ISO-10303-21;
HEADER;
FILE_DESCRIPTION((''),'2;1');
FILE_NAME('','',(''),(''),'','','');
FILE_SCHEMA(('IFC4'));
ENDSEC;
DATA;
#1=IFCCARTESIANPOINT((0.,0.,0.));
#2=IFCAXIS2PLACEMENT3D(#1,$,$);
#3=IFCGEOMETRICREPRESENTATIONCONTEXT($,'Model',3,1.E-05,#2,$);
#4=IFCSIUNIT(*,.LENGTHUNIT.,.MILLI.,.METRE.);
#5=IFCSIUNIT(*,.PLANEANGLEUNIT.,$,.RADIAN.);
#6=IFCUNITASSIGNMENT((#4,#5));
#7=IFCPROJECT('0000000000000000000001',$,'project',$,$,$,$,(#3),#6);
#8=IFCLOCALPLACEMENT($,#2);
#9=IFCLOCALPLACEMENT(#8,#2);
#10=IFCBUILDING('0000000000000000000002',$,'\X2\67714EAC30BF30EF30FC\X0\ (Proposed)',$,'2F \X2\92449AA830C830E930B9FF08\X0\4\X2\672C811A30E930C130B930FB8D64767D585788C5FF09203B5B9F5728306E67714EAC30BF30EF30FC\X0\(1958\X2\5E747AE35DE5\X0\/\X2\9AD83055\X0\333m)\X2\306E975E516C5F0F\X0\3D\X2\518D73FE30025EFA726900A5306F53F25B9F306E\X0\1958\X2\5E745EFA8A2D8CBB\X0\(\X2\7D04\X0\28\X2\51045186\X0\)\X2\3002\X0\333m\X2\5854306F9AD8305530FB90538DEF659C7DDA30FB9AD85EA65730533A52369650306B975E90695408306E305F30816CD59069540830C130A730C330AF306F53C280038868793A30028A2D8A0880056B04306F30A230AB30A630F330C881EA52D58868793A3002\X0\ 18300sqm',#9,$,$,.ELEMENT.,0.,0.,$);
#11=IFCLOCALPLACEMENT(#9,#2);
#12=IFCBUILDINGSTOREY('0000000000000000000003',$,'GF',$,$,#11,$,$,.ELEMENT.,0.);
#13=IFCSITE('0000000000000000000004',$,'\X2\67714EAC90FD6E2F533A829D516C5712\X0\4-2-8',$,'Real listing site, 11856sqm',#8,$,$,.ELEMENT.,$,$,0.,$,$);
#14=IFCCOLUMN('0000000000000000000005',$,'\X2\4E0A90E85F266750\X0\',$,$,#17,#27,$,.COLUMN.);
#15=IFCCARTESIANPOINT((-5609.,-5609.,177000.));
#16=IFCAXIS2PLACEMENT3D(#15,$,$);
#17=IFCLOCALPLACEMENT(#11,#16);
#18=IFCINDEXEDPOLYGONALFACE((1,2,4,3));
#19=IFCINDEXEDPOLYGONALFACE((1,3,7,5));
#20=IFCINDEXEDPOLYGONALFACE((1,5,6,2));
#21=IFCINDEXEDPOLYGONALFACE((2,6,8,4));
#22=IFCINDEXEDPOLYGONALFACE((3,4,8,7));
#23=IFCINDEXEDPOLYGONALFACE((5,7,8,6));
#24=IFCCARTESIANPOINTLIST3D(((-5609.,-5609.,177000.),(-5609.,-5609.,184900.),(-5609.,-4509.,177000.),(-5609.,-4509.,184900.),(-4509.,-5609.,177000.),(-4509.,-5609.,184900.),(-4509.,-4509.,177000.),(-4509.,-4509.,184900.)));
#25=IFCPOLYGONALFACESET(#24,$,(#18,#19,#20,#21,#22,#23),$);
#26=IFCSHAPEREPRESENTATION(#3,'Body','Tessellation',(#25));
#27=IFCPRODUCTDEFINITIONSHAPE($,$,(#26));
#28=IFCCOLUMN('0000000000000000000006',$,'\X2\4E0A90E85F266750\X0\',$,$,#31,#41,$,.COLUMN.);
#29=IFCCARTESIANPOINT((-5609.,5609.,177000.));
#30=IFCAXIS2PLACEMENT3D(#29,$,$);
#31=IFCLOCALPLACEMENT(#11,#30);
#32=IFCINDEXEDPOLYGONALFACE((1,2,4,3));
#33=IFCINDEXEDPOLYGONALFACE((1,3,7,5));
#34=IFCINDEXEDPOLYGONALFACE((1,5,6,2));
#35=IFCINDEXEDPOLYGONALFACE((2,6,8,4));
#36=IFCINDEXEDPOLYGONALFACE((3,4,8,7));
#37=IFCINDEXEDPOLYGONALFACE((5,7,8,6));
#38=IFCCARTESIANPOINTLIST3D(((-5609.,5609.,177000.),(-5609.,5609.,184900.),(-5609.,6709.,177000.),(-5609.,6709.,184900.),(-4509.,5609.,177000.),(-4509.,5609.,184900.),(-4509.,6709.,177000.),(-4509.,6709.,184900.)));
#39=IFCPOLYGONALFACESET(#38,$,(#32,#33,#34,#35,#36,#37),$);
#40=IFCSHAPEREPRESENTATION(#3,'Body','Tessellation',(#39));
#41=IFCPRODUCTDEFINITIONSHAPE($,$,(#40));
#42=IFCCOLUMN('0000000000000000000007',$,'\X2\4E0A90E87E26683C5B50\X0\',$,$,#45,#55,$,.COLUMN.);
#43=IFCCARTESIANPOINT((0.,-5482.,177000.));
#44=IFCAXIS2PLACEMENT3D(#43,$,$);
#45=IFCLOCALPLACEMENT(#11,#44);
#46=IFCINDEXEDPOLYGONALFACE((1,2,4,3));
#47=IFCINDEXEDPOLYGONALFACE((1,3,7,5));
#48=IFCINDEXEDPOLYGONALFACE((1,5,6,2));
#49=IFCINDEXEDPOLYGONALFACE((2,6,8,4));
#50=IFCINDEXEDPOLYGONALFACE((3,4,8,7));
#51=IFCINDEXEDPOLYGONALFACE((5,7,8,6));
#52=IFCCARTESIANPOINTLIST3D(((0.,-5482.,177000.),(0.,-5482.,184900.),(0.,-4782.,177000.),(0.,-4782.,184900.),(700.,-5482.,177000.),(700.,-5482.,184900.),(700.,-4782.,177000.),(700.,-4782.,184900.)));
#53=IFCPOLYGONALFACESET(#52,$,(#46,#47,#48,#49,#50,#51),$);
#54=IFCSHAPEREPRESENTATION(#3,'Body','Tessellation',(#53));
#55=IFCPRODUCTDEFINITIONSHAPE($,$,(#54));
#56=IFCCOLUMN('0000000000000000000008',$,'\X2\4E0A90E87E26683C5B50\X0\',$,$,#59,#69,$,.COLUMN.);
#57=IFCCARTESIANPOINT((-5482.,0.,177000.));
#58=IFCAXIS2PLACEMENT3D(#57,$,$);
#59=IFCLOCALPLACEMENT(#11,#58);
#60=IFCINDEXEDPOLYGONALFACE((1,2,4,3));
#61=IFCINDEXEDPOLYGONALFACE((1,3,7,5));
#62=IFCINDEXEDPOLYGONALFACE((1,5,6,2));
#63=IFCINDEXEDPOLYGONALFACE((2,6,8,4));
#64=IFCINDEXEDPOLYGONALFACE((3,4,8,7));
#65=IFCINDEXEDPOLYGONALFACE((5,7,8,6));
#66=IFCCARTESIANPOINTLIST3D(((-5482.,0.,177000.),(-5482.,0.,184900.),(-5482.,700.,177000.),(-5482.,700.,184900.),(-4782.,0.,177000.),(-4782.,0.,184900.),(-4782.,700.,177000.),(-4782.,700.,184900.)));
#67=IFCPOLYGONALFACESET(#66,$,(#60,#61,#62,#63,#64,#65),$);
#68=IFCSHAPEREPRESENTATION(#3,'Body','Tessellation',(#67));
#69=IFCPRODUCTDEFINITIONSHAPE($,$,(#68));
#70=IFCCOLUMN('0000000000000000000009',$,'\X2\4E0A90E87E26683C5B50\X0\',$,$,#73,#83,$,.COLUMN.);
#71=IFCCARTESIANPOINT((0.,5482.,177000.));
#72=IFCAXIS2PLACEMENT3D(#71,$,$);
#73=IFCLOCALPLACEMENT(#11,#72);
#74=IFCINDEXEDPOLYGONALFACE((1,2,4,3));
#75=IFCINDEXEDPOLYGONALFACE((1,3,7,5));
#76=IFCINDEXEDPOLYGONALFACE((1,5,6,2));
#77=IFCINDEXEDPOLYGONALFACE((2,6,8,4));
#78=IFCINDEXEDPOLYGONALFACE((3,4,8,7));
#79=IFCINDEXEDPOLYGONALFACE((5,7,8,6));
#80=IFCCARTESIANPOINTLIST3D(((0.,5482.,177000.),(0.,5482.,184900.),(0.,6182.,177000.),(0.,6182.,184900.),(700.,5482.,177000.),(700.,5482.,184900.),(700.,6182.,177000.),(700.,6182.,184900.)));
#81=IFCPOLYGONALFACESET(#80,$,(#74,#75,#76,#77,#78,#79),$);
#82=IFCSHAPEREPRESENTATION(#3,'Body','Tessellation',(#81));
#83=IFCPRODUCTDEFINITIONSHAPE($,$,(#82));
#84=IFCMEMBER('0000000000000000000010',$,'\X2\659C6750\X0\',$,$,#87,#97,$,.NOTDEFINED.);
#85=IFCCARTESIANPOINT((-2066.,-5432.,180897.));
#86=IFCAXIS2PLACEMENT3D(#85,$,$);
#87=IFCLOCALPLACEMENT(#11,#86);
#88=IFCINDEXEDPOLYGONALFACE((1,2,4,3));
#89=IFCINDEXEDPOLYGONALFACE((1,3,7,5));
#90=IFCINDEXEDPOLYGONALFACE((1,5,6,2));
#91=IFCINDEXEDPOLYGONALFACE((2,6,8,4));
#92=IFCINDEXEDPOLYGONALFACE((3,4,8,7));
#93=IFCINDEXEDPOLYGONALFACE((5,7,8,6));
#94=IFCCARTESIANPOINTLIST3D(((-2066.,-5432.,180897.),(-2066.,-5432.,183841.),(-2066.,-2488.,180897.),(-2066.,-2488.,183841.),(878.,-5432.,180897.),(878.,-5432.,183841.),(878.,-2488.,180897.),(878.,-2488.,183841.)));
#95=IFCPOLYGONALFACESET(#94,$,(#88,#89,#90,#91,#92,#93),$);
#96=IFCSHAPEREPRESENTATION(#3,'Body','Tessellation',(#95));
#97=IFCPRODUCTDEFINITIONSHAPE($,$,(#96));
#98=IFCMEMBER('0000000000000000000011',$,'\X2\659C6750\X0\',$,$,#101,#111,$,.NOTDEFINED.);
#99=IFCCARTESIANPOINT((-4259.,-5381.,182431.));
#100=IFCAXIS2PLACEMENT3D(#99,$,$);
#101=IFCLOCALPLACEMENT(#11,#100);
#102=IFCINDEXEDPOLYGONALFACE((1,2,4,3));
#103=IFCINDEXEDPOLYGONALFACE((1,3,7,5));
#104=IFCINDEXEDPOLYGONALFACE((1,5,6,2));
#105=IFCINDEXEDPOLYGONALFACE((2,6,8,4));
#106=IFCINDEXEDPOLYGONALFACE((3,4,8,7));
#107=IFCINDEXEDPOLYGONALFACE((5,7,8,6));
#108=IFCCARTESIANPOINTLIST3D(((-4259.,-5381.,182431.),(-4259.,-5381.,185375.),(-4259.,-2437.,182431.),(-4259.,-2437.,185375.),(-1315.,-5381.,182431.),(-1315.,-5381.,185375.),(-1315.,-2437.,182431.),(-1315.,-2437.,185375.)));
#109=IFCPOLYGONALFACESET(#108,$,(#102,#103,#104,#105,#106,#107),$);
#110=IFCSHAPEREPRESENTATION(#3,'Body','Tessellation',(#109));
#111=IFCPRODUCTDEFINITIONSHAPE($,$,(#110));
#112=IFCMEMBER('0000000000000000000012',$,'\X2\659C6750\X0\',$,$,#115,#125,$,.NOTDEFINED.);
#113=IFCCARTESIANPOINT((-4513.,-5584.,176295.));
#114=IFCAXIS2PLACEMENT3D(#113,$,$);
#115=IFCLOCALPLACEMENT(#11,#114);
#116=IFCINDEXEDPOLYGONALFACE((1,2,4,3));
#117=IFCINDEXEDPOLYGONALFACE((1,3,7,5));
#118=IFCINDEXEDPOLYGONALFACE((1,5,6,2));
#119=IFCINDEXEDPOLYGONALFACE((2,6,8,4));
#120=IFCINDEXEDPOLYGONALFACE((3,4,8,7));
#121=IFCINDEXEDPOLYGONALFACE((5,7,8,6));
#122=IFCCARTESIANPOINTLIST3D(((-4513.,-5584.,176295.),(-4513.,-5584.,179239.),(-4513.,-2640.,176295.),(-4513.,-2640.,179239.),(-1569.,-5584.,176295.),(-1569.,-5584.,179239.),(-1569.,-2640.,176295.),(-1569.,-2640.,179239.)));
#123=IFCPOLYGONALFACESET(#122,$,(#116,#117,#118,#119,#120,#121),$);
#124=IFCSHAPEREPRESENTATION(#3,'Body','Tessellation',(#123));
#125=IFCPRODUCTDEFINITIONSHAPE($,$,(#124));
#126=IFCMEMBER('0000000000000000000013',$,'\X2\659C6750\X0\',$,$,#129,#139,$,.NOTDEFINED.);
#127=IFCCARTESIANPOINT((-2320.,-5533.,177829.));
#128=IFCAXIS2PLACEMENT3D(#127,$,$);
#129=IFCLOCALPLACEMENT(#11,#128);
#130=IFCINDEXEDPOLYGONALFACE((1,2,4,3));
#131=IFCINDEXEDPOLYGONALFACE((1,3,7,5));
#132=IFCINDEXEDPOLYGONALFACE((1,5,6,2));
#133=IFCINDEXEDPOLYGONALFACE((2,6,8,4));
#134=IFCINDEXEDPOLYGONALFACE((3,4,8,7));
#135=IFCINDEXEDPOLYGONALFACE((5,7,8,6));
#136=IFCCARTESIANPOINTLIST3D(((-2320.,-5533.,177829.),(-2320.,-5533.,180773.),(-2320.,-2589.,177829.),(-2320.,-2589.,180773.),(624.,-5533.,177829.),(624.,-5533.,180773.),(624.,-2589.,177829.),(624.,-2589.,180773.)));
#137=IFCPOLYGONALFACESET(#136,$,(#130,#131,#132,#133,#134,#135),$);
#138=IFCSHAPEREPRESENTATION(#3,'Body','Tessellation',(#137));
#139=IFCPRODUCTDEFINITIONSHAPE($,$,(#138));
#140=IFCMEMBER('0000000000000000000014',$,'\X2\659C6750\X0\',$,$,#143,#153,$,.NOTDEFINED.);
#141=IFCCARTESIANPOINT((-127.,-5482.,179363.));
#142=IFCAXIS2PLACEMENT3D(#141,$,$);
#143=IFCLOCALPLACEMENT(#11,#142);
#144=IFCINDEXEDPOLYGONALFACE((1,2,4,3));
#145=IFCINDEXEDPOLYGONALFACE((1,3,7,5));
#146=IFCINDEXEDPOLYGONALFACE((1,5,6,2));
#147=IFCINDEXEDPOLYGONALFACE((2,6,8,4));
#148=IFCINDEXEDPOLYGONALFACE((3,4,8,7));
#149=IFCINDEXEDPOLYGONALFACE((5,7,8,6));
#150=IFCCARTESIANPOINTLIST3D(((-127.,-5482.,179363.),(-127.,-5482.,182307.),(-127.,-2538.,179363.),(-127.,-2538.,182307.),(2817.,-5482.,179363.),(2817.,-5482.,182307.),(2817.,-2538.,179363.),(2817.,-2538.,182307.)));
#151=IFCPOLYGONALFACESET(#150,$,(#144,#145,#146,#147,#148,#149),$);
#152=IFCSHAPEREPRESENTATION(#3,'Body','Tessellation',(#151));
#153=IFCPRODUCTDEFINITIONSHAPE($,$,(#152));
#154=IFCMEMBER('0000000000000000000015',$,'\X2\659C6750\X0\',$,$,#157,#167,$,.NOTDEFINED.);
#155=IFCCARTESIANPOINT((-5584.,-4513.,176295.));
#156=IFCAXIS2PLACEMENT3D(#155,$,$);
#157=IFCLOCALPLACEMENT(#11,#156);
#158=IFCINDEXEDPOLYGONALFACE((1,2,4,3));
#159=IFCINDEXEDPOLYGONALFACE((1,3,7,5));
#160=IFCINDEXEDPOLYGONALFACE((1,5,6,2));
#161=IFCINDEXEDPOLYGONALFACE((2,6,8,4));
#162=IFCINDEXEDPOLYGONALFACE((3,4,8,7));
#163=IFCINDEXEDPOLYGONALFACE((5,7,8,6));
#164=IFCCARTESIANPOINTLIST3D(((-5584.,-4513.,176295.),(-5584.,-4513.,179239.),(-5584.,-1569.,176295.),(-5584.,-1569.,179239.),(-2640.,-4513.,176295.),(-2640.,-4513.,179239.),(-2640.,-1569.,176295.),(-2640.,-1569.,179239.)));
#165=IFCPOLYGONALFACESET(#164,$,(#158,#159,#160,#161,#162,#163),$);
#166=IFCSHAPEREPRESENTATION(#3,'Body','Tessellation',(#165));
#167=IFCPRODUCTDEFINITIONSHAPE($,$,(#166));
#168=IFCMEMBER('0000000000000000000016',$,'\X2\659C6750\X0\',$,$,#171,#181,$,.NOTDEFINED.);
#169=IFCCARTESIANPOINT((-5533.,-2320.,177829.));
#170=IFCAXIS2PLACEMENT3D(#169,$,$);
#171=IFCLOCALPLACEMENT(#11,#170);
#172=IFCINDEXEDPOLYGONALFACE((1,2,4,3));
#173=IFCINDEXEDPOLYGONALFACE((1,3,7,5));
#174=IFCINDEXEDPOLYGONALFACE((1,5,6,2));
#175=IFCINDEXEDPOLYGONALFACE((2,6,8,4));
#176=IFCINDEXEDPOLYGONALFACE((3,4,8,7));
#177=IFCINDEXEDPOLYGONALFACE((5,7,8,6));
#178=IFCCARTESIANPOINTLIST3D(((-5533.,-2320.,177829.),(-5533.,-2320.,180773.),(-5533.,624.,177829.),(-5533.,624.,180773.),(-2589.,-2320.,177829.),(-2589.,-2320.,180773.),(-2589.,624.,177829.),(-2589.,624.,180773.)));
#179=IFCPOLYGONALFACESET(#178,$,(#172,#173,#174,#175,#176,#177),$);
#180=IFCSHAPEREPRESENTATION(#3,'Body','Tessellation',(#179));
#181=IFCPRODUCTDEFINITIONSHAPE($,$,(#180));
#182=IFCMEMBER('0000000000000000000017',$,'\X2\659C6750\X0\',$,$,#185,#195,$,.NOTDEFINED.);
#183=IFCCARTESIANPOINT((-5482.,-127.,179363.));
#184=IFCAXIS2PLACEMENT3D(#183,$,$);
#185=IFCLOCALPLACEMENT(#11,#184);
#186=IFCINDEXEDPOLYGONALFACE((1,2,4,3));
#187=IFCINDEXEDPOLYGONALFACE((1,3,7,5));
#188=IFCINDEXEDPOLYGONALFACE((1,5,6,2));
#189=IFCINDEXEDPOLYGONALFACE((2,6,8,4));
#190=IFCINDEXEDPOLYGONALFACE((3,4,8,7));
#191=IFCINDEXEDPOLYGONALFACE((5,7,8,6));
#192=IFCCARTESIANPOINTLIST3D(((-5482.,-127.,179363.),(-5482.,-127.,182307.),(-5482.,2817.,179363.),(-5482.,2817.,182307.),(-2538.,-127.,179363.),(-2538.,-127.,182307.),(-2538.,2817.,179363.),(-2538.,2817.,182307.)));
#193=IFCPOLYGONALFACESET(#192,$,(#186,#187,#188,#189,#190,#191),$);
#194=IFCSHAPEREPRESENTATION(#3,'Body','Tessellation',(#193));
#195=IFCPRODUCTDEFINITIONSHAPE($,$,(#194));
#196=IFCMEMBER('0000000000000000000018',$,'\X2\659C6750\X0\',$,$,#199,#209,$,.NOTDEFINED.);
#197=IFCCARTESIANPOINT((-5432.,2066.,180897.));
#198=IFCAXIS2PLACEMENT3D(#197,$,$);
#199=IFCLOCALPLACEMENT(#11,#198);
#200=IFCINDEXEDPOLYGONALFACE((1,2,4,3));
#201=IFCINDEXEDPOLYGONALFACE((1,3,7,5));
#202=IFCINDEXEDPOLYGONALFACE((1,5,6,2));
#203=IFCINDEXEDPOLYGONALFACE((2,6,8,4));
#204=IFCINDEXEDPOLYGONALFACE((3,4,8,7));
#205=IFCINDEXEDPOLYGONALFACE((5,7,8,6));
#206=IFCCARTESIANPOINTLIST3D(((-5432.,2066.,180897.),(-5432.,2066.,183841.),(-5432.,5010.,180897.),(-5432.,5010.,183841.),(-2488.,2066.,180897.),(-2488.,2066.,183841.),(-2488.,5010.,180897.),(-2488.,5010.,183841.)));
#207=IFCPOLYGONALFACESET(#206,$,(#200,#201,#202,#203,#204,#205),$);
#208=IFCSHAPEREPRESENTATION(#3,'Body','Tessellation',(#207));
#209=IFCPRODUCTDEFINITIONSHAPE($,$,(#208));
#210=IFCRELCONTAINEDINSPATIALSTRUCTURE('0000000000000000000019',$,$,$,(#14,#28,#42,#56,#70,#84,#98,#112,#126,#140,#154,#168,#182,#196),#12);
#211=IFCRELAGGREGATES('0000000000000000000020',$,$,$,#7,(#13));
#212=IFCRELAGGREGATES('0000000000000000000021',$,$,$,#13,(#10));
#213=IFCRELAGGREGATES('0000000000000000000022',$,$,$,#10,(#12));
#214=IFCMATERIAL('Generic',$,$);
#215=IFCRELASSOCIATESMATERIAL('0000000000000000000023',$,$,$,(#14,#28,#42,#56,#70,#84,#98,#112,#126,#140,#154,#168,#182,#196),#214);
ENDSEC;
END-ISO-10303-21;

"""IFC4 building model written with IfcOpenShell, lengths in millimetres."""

from ifc_helpers import new_model, si_unit, frame, frame_2d, origin, place, context, project, spatial, rectangle, extrude, material, element, save


model = new_model("IFC4")

# Units and contexts
model_context = context("Model", 3, precision=1e-05, world=origin())
ifc_project = project(units=[si_unit("LENGTHUNIT", "METRE", prefix="MILLI"), si_unit("PLANEANGLEUNIT", "RADIAN")], contexts=[model_context])

# Site, building, storey
site_placement = place(None, origin())
site = spatial("IfcSite", under=ifc_project, at=site_placement, Name="東京都港区芝公園4-2-8", ObjectType="Real listing site, 11856sqm", CompositionType="ELEMENT", RefElevation=0.0)
building_placement = place(site_placement, origin())
building = spatial("IfcBuilding", under=site, at=building_placement, Name="東京タワー (Proposed)", ObjectType="2F 鉄骨トラス（4本脚ラチス・赤白塗装）※実在の東京タワー(1958年竣工/高さ333m)の非公式3D再現。建物¥は史実の1958年建設費(約28億円)。333m塔は高さ・道路斜線・高度地区制限に非適合のため法適合チェックは参考表示。設計者欄はアカウント自動表示。 18300sqm", CompositionType="ELEMENT", ElevationOfRefHeight=0.0, ElevationOfTerrain=0.0)
storey_placement = place(building_placement, origin())
storey = spatial("IfcBuildingStorey", under=building, at=storey_placement, Name="GF", CompositionType="ELEMENT", Elevation=0.0)

# Columns
ifc_material = material(Name="Generic")
column_1_placement = place(storey_placement, frame((-5609.0, -5609.0, 177000.0)))
element("IfcColumn", 1, at=column_1_placement, inside=storey, material=ifc_material, Name="上部弦材", PredefinedType="COLUMN", context=model_context, shape_type="SweptSolid", body=[
    extrude(rectangle(XDim=1100.0, YDim=1100.0, at=frame_2d((550.0, 550.0))), frame((-5609.0, -5609.0, 177000.0)), (0.0, 0.0, 1.0), 7900.0),
])
column_2_placement = place(storey_placement, frame((-5609.0, 5609.0, 177000.0)))
element("IfcColumn", 2, at=column_2_placement, inside=storey, material=ifc_material, Name="上部弦材", PredefinedType="COLUMN", context=model_context, shape_type="SweptSolid", body=[
    extrude(rectangle(XDim=1100.0, YDim=1100.0, at=frame_2d((550.0, 550.0))), frame((-5609.0, 5609.0, 177000.0)), (0.0, 0.0, 1.0), 7900.0),
])
column_3_placement = place(storey_placement, frame((0.0, -5482.0, 177000.0)))
element("IfcColumn", 3, at=column_3_placement, inside=storey, material=ifc_material, Name="上部縦格子", PredefinedType="COLUMN", context=model_context, shape_type="SweptSolid", body=[
    extrude(rectangle(XDim=700.0, YDim=700.0, at=frame_2d((350.0, 350.0))), frame((0.0, -5482.0, 177000.0)), (0.0, 0.0, 1.0), 7900.0),
])
column_4_placement = place(storey_placement, frame((-5482.0, 0.0, 177000.0)))
element("IfcColumn", 4, at=column_4_placement, inside=storey, material=ifc_material, Name="上部縦格子", PredefinedType="COLUMN", context=model_context, shape_type="SweptSolid", body=[
    extrude(rectangle(XDim=700.0, YDim=700.0, at=frame_2d((350.0, 350.0))), frame((-5482.0, 0.0, 177000.0)), (0.0, 0.0, 1.0), 7900.0),
])
column_5_placement = place(storey_placement, frame((0.0, 5482.0, 177000.0)))
element("IfcColumn", 5, at=column_5_placement, inside=storey, material=ifc_material, Name="上部縦格子", PredefinedType="COLUMN", context=model_context, shape_type="SweptSolid", body=[
    extrude(rectangle(XDim=700.0, YDim=700.0, at=frame_2d((350.0, 350.0))), frame((0.0, 5482.0, 177000.0)), (0.0, 0.0, 1.0), 7900.0),
])

# Members
member_1_placement = place(storey_placement, frame((-2066.0, -5432.0, 180897.0)))
element("IfcMember", 6, at=member_1_placement, inside=storey, material=ifc_material, Name="斜材", PredefinedType="NOTDEFINED", context=model_context, shape_type="SweptSolid", body=[
    extrude(rectangle(XDim=2944.0, YDim=2944.0, at=frame_2d((1472.0, 1472.0))), frame((-2066.0, -5432.0, 180897.0)), (0.0, 0.0, 1.0), 2944.0),
])
member_2_placement = place(storey_placement, frame((-4259.0, -5381.0, 182431.0)))
element("IfcMember", 7, at=member_2_placement, inside=storey, material=ifc_material, Name="斜材", PredefinedType="NOTDEFINED", context=model_context, shape_type="SweptSolid", body=[
    extrude(rectangle(XDim=2944.0, YDim=2944.0, at=frame_2d((1472.0, 1472.0))), frame((-4259.0, -5381.0, 182431.0)), (0.0, 0.0, 1.0), 2944.0),
])
member_3_placement = place(storey_placement, frame((-4513.0, -5584.0, 176295.0)))
element("IfcMember", 8, at=member_3_placement, inside=storey, material=ifc_material, Name="斜材", PredefinedType="NOTDEFINED", context=model_context, shape_type="SweptSolid", body=[
    extrude(rectangle(XDim=2944.0, YDim=2944.0, at=frame_2d((1472.0, 1472.0))), frame((-4513.0, -5584.0, 176295.0)), (0.0, 0.0, 1.0), 2944.0),
])
member_4_placement = place(storey_placement, frame((-2320.0, -5533.0, 177829.0)))
element("IfcMember", 9, at=member_4_placement, inside=storey, material=ifc_material, Name="斜材", PredefinedType="NOTDEFINED", context=model_context, shape_type="SweptSolid", body=[
    extrude(rectangle(XDim=2944.0, YDim=2944.0, at=frame_2d((1472.0, 1472.0))), frame((-2320.0, -5533.0, 177829.0)), (0.0, 0.0, 1.0), 2944.0),
])
member_5_placement = place(storey_placement, frame((-127.0, -5482.0, 179363.0)))
element("IfcMember", 10, at=member_5_placement, inside=storey, material=ifc_material, Name="斜材", PredefinedType="NOTDEFINED", context=model_context, shape_type="SweptSolid", body=[
    extrude(rectangle(XDim=2944.0, YDim=2944.0, at=frame_2d((1472.0, 1472.0))), frame((-127.0, -5482.0, 179363.0)), (0.0, 0.0, 1.0), 2944.0),
])
member_6_placement = place(storey_placement, frame((-5584.0, -4513.0, 176295.0)))
element("IfcMember", 11, at=member_6_placement, inside=storey, material=ifc_material, Name="斜材", PredefinedType="NOTDEFINED", context=model_context, shape_type="SweptSolid", body=[
    extrude(rectangle(XDim=2944.0, YDim=2944.0, at=frame_2d((1472.0, 1472.0))), frame((-5584.0, -4513.0, 176295.0)), (0.0, 0.0, 1.0), 2944.0),
])
member_7_placement = place(storey_placement, frame((-5533.0, -2320.0, 177829.0)))
element("IfcMember", 12, at=member_7_placement, inside=storey, material=ifc_material, Name="斜材", PredefinedType="NOTDEFINED", context=model_context, shape_type="SweptSolid", body=[
    extrude(rectangle(XDim=2944.0, YDim=2944.0, at=frame_2d((1472.0, 1472.0))), frame((-5533.0, -2320.0, 177829.0)), (0.0, 0.0, 1.0), 2944.0),
])
member_8_placement = place(storey_placement, frame((-5482.0, -127.0, 179363.0)))
element("IfcMember", 13, at=member_8_placement, inside=storey, material=ifc_material, Name="斜材", PredefinedType="NOTDEFINED", context=model_context, shape_type="SweptSolid", body=[
    extrude(rectangle(XDim=2944.0, YDim=2944.0, at=frame_2d((1472.0, 1472.0))), frame((-5482.0, -127.0, 179363.0)), (0.0, 0.0, 1.0), 2944.0),
])
member_9_placement = place(storey_placement, frame((-5432.0, 2066.0, 180897.0)))
element("IfcMember", 14, at=member_9_placement, inside=storey, material=ifc_material, Name="斜材", PredefinedType="NOTDEFINED", context=model_context, shape_type="SweptSolid", body=[
    extrude(rectangle(XDim=2944.0, YDim=2944.0, at=frame_2d((1472.0, 1472.0))), frame((-5432.0, 2066.0, 180897.0)), (0.0, 0.0, 1.0), 2944.0),
])

save(model, "model.ifc")
